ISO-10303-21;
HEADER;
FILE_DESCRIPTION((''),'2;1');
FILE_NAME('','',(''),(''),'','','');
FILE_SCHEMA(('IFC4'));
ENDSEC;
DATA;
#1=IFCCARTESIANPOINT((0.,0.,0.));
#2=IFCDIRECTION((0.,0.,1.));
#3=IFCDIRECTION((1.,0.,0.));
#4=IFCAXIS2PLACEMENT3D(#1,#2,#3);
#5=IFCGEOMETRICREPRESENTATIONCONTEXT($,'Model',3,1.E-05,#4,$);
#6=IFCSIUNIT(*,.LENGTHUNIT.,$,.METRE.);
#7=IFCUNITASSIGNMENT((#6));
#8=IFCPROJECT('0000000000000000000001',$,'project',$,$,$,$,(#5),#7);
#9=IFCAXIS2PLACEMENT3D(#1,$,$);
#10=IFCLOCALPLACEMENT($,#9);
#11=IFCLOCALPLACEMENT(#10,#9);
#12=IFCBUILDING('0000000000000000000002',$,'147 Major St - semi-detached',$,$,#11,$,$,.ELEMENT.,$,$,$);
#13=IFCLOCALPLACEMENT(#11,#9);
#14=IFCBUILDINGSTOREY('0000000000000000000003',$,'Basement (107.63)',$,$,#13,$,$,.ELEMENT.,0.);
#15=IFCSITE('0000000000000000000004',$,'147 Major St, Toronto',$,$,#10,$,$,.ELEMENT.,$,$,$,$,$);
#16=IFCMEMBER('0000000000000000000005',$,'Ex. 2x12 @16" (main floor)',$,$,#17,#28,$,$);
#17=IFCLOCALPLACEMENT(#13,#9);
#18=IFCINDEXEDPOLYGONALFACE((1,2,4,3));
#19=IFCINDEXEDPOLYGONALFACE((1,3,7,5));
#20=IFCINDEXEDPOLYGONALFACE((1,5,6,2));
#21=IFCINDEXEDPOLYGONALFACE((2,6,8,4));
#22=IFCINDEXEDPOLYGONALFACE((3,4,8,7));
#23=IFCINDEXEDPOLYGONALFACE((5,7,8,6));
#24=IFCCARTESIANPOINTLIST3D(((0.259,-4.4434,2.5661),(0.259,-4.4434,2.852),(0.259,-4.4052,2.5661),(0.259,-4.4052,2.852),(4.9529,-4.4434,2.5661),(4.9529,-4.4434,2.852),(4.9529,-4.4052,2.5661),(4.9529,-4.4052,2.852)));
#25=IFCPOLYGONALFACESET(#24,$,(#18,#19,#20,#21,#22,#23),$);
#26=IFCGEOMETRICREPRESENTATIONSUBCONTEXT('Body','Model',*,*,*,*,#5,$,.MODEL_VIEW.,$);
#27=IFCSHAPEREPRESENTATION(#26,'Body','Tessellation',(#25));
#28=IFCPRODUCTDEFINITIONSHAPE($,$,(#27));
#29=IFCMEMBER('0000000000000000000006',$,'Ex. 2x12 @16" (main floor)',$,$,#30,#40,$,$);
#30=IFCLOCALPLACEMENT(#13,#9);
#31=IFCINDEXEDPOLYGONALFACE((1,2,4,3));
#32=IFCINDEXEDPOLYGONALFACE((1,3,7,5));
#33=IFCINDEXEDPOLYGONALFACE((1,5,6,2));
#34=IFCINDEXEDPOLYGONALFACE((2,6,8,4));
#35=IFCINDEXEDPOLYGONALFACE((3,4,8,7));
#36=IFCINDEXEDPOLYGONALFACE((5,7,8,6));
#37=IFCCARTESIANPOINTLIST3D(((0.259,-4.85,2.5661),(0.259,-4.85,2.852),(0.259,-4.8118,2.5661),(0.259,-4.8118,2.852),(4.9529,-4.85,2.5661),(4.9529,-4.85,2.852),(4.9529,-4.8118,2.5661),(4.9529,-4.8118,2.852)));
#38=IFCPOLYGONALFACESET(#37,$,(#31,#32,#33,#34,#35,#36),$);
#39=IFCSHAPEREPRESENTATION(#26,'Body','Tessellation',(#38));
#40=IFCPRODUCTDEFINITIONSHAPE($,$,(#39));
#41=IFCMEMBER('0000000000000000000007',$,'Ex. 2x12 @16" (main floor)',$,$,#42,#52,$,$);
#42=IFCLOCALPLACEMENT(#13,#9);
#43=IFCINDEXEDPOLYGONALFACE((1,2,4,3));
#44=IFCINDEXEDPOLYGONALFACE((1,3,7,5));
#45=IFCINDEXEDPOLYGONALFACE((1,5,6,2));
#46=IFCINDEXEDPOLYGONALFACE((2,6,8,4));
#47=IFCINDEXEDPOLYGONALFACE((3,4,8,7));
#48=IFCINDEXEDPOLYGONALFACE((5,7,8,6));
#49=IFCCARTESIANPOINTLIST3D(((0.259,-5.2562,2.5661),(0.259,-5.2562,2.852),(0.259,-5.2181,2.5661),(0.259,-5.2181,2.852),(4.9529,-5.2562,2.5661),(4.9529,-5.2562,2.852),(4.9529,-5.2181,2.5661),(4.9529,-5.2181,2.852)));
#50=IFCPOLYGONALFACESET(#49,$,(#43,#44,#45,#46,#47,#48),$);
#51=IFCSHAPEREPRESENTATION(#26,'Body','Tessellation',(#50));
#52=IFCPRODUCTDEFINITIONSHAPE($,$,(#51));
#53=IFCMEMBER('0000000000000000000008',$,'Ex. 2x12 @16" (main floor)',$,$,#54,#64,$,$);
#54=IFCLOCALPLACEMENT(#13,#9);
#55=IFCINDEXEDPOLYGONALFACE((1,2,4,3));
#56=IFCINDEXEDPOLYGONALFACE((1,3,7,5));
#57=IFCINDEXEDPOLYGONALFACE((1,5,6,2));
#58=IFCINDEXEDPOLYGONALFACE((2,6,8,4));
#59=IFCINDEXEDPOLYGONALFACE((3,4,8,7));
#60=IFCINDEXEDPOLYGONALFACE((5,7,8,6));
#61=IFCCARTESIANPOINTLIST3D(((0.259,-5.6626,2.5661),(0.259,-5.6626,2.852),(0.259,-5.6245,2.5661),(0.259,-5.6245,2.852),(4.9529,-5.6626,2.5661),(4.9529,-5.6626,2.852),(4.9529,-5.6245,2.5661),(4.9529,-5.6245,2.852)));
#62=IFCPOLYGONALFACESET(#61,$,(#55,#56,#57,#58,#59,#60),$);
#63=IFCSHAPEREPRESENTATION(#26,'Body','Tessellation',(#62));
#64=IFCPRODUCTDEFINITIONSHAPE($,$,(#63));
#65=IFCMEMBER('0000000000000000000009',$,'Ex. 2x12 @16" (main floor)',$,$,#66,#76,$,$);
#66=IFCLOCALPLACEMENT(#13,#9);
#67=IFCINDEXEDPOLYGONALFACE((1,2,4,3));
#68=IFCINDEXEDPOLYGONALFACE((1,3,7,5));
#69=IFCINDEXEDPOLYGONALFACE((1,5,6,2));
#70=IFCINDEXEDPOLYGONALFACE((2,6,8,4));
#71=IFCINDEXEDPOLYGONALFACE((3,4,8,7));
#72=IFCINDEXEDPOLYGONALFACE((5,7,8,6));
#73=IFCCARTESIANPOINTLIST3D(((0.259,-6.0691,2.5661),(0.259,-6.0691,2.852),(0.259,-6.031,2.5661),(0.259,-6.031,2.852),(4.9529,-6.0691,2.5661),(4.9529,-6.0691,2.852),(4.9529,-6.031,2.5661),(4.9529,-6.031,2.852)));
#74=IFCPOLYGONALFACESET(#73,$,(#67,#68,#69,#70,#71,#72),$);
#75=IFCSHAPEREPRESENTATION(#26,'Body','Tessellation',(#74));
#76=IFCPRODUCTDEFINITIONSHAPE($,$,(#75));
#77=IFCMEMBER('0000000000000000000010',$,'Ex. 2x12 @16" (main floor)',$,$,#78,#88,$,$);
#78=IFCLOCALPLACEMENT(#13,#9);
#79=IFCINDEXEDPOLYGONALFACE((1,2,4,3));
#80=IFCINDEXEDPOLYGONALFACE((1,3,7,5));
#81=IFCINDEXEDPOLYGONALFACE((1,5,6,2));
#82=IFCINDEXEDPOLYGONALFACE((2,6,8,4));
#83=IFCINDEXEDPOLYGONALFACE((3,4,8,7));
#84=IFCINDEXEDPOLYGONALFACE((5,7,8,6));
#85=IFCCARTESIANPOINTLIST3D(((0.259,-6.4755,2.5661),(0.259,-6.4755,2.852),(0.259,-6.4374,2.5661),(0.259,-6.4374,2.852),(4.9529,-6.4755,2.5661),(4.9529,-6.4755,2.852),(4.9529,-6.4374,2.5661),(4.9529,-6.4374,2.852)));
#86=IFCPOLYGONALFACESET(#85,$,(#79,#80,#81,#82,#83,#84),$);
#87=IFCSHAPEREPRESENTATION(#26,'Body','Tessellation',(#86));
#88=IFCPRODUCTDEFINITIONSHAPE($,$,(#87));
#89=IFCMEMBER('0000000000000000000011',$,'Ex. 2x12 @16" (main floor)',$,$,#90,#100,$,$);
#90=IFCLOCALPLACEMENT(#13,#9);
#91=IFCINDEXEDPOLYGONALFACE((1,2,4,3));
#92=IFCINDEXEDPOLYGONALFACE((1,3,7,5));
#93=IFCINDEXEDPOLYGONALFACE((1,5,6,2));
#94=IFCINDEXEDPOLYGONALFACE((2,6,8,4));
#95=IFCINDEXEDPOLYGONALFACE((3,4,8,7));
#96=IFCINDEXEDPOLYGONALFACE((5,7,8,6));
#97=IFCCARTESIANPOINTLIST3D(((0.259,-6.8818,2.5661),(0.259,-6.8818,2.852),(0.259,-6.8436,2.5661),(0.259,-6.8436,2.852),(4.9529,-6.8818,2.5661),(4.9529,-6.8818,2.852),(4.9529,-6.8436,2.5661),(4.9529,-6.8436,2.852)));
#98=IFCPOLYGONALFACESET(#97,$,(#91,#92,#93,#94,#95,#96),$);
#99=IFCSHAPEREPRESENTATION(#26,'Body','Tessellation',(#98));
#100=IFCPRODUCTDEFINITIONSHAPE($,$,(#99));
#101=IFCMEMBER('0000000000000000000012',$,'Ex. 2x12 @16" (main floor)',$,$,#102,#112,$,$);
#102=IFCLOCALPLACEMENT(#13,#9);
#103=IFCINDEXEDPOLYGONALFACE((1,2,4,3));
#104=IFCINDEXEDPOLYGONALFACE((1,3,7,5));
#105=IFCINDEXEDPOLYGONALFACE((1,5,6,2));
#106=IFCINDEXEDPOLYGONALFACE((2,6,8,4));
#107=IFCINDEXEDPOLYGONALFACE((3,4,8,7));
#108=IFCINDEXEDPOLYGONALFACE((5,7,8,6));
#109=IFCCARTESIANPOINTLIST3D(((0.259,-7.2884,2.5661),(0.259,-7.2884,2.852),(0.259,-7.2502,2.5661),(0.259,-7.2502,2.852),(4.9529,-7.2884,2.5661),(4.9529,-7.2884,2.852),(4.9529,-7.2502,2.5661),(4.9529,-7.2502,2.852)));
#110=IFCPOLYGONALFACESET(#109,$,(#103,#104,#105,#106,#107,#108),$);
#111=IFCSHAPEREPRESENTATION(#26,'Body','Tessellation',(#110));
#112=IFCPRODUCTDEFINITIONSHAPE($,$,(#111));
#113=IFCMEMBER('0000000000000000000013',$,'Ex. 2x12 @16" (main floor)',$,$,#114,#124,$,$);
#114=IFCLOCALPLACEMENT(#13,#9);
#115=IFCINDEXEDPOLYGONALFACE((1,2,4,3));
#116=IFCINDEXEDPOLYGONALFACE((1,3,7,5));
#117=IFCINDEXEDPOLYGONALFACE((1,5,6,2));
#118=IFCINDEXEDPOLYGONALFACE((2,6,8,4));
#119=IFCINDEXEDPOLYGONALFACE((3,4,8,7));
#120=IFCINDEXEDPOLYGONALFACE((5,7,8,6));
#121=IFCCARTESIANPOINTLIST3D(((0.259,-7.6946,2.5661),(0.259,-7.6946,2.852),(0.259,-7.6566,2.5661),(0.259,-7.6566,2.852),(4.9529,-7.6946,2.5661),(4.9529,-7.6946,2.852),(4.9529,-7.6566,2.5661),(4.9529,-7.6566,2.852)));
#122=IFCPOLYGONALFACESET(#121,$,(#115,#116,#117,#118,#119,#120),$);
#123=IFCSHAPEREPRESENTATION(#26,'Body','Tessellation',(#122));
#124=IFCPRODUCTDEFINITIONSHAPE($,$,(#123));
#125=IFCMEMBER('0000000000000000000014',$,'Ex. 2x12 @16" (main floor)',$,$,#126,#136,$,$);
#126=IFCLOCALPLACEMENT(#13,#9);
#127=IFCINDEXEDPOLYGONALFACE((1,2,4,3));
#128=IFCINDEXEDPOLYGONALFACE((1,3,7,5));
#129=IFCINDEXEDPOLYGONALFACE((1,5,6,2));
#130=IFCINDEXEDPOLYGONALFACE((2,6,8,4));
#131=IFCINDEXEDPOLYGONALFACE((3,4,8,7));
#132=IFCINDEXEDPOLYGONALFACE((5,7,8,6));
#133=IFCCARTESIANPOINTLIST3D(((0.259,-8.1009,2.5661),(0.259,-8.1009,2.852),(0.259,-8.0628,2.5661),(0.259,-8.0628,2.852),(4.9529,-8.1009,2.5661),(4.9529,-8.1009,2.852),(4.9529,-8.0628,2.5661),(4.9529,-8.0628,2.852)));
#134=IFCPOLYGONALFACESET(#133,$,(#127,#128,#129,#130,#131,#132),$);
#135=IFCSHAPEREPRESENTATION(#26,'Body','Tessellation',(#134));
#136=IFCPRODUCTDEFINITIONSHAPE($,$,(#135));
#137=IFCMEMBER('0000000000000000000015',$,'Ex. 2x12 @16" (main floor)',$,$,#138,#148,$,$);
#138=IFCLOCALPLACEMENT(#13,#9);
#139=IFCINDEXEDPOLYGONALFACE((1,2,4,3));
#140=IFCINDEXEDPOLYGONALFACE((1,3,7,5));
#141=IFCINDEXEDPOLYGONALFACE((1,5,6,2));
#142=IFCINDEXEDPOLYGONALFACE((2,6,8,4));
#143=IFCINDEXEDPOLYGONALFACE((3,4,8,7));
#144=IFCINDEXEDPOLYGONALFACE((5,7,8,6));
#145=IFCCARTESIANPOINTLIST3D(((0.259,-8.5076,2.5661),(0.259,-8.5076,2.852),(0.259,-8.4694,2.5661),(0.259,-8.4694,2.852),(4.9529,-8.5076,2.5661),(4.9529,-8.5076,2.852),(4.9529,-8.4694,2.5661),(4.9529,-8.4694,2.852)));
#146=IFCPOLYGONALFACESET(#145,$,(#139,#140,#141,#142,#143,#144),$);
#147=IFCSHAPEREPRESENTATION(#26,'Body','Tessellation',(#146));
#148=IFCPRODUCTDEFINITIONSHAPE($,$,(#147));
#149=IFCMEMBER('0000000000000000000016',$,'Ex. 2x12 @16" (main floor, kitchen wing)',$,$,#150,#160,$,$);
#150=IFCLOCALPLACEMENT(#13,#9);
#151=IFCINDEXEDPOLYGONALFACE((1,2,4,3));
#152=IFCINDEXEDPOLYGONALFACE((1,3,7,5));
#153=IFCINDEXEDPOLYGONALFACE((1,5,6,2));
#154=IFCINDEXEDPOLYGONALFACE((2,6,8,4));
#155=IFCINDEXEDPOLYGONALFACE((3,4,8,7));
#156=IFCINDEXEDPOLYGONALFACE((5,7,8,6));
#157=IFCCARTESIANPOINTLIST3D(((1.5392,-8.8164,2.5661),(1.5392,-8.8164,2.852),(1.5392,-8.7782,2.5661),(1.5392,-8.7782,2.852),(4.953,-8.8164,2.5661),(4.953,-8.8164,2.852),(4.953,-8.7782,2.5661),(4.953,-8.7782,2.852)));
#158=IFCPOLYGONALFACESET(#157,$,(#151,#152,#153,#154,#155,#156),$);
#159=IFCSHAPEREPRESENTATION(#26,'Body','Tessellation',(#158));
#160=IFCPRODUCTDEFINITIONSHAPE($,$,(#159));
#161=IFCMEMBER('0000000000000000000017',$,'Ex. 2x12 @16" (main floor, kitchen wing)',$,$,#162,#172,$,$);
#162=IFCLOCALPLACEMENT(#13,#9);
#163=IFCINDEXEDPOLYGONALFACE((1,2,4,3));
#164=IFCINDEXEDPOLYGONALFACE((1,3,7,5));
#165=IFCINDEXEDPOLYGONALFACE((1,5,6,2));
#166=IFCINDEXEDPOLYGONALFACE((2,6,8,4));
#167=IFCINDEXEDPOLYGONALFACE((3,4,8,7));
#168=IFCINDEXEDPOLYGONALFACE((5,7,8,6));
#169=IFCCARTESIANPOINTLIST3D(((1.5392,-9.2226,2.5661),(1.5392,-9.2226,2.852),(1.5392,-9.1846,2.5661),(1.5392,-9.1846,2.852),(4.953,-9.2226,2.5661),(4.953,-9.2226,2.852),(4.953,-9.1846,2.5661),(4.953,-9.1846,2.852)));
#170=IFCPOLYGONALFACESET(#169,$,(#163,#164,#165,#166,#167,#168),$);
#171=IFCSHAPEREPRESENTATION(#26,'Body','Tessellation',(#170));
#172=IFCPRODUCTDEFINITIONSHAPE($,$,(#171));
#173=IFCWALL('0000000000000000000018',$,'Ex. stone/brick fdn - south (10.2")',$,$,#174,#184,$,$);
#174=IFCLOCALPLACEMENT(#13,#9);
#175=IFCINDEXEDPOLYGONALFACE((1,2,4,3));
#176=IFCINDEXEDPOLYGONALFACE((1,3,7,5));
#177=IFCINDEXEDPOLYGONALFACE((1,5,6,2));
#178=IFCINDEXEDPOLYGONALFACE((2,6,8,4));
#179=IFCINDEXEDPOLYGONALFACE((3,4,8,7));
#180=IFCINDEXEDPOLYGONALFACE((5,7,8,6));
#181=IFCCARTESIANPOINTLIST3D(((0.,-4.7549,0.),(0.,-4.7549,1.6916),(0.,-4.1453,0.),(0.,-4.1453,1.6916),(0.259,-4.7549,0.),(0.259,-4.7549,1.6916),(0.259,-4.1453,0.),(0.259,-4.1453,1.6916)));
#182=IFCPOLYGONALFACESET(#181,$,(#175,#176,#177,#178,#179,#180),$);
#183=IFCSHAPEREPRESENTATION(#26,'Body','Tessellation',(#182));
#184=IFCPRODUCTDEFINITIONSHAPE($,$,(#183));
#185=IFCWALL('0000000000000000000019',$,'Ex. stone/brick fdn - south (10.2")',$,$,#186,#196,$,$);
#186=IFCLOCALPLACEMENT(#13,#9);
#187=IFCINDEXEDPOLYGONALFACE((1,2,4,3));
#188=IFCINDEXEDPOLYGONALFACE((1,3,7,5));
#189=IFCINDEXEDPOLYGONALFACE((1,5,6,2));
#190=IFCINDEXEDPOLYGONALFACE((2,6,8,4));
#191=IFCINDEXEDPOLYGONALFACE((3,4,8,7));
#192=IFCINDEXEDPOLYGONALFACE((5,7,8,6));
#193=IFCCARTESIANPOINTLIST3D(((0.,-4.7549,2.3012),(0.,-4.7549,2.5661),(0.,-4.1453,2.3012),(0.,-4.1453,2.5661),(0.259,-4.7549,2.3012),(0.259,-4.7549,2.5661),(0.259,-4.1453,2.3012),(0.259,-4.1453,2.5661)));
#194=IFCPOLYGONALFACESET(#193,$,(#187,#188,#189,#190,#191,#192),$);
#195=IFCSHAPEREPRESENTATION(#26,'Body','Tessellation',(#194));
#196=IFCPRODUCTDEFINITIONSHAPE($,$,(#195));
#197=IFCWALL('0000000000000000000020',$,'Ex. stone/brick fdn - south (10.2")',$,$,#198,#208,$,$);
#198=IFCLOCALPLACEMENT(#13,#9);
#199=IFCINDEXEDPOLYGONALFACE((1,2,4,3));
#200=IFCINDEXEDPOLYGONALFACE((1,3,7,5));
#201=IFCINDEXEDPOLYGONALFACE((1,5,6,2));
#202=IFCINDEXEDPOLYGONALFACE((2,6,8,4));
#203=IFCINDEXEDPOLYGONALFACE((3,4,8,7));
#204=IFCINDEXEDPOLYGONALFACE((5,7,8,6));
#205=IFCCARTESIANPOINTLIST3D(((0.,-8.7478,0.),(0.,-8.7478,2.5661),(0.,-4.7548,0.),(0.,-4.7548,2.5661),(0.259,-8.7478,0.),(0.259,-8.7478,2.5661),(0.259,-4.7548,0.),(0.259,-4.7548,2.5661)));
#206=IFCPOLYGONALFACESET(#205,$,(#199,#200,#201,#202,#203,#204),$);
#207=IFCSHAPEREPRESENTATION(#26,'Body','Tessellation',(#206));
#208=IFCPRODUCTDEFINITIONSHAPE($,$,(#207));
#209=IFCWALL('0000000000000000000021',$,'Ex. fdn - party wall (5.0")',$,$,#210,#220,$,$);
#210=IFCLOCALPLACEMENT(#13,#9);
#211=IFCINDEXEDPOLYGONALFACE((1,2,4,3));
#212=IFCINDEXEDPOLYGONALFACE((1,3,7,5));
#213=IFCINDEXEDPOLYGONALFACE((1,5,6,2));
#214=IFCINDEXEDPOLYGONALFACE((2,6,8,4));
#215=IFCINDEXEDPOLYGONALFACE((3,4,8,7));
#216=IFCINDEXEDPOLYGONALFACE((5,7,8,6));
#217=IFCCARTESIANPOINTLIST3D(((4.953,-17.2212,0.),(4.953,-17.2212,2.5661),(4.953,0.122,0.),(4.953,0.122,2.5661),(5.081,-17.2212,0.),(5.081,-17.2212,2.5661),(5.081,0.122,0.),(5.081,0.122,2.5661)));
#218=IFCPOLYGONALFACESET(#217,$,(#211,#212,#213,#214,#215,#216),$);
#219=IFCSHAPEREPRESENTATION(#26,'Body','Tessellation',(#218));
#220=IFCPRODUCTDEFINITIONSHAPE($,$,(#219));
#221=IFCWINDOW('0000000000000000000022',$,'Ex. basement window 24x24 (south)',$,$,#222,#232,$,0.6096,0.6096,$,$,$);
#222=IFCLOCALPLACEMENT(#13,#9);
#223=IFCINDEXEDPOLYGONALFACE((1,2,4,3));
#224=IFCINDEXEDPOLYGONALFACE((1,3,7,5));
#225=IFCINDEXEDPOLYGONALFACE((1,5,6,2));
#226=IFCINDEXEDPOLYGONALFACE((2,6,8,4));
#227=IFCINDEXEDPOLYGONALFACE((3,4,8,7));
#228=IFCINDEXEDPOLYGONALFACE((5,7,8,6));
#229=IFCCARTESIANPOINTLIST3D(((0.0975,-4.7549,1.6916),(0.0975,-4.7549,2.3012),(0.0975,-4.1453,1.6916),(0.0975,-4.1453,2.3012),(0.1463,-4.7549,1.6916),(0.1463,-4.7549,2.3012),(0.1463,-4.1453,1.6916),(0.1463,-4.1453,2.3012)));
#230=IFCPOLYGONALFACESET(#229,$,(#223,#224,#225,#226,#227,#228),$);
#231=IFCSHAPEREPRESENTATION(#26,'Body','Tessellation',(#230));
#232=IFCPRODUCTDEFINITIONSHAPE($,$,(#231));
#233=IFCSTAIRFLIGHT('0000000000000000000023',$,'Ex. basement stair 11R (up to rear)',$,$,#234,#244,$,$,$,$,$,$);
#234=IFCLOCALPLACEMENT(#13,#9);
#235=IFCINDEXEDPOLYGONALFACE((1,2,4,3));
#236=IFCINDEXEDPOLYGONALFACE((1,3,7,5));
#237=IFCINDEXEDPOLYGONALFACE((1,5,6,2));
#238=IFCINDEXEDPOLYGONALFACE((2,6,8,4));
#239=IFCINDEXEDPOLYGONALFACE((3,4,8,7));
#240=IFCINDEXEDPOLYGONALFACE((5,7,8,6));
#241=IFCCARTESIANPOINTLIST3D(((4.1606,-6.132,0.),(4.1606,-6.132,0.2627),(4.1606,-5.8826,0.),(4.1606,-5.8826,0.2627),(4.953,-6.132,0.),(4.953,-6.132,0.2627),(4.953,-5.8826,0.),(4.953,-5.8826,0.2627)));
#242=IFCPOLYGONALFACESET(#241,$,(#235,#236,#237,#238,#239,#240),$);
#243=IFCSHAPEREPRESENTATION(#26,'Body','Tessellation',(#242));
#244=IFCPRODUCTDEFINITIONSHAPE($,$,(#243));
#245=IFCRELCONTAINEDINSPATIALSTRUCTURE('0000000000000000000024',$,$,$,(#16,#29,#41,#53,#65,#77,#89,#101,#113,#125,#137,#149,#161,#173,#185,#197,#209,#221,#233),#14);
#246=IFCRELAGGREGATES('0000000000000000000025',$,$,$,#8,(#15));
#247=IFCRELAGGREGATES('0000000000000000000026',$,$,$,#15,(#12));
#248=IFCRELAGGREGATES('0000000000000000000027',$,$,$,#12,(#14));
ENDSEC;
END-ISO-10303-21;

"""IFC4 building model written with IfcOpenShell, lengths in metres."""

from ifc_helpers import new_model, si_unit, frame, origin, origin_with_axes, place, context, subcontext, project, spatial, rectangle, extrude, element, save


model = new_model("IFC4")

# Units and contexts
model_context = context("Model", 3, precision=1e-05, world=origin_with_axes())
body_context = subcontext(model_context, "Body", "Model", "MODEL_VIEW")
ifc_project = project(units=[si_unit("LENGTHUNIT", "METRE")], contexts=[model_context])

# Site, building, storey
site_placement = place(None, origin())
site = spatial("IfcSite", under=ifc_project, at=site_placement, Name="147 Major St, Toronto", CompositionType="ELEMENT")
building_placement = place(site_placement, origin())
building = spatial("IfcBuilding", under=site, at=building_placement, Name="147 Major St - semi-detached", CompositionType="ELEMENT")
storey_placement = place(building_placement, origin())
storey = spatial("IfcBuildingStorey", under=building, at=storey_placement, Name="Basement (107.63)", CompositionType="ELEMENT", Elevation=0.0)

# Members
for number, where, name in (
    (1, (2.606, -4.4243, 2.5661), "Ex. 2x12 @16\" (main floor)"),
    (2, (2.606, -4.8309, 2.5661), "Ex. 2x12 @16\" (main floor)"),
    (3, (2.606, -5.2372, 2.5661), "Ex. 2x12 @16\" (main floor)"),
    (4, (2.606, -5.6435, 2.5661), "Ex. 2x12 @16\" (main floor)"),
    (5, (2.606, -6.0501, 2.5661), "Ex. 2x12 @16\" (main floor)"),
    (6, (2.606, -6.4564, 2.5661), "Ex. 2x12 @16\" (main floor)"),
    (7, (2.606, -6.8627, 2.5661), "Ex. 2x12 @16\" (main floor)"),
    (8, (2.606, -7.2693, 2.5661), "Ex. 2x12 @16\" (main floor)"),
    (9, (2.606, -7.6756, 2.5661), "Ex. 2x12 @16\" (main floor)"),
    (10, (2.606, -8.0819, 2.5661), "Ex. 2x12 @16\" (main floor)"),
    (11, (2.606, -8.4885, 2.5661), "Ex. 2x12 @16\" (main floor)"),
):
    element("IfcMember", number, at=place(storey_placement, frame(where)), inside=storey, Name=name, context=body_context, shape_type="SweptSolid", body=[
        extrude(rectangle(XDim=4.6939, YDim=0.0381), origin_with_axes(), (0.0, 0.0, 1.0), 0.2859),
    ])
for number, where, name in (
    (12, (3.2461, -8.7973, 2.5661), "Ex. 2x12 @16\" (main floor, kitchen wing)"),
    (13, (3.2461, -9.2036, 2.5661), "Ex. 2x12 @16\" (main floor, kitchen wing)"),
):
    element("IfcMember", number, at=place(storey_placement, frame(where)), inside=storey, Name=name, context=body_context, shape_type="SweptSolid", body=[
        extrude(rectangle(XDim=3.4138, YDim=0.0381), origin_with_axes(), (0.0, 0.0, 1.0), 0.2859),
    ])

# Walls
wall_1_placement = place(storey_placement, frame((0.1295, -4.4501, 0.0)))
element("IfcWall", 14, at=wall_1_placement, inside=storey, Name="Ex. stone/brick fdn - south (10.2\")", context=body_context, shape_type="SweptSolid", body=[
    extrude(rectangle(XDim=0.2591, YDim=0.6096), origin_with_axes(), (0.0, 0.0, 1.0), 1.6916),
])
wall_2_placement = place(storey_placement, frame((0.1295, -4.4501, 2.3012)))
element("IfcWall", 15, at=wall_2_placement, inside=storey, Name="Ex. stone/brick fdn - south (10.2\")", context=body_context, shape_type="SweptSolid", body=[
    extrude(rectangle(XDim=0.2591, YDim=0.6096), origin_with_axes(), (0.0, 0.0, 1.0), 0.2649),
])
wall_3_placement = place(storey_placement, frame((0.1295, -6.7513, 0.0)))
element("IfcWall", 16, at=wall_3_placement, inside=storey, Name="Ex. stone/brick fdn - south (10.2\")", context=body_context, shape_type="SweptSolid", body=[
    extrude(rectangle(XDim=0.2591, YDim=3.9929), origin_with_axes(), (0.0, 0.0, 1.0), 2.5661),
])
wall_4_placement = place(storey_placement, frame((5.017, -8.5496, 0.0)))
element("IfcWall", 17, at=wall_4_placement, inside=storey, Name="Ex. fdn - party wall (5.0\")", context=body_context, shape_type="SweptSolid", body=[
    extrude(rectangle(XDim=0.128, YDim=17.3431), origin_with_axes(), (0.0, 0.0, 1.0), 2.5661),
])

# Window
window_placement = place(storey_placement, frame((0.1219, -4.4501, 1.6916)))
element("IfcWindow", 18, at=window_placement, inside=storey, Name="Ex. basement window 24x24 (south)", OverallHeight=0.6096, OverallWidth=0.6096, context=body_context, shape_type="SweptSolid", body=[
    extrude(rectangle(XDim=0.0488, YDim=0.6096), origin_with_axes(), (0.0, 0.0, 1.0), 0.6096),
])

# Stair flight
for number, where, name in (
    (19, (4.5568, -6.0073, 0.0), "Ex. basement stair 11R (up to rear)"),
):
    element("IfcStairFlight", number, at=place(storey_placement, frame(where)), inside=storey, Name=name, context=body_context, shape_type="SweptSolid", body=[
        extrude(rectangle(XDim=0.7925, YDim=0.2493), origin_with_axes(), (0.0, 0.0, 1.0), 0.2627),
    ])

save(model, "model.ifc")
